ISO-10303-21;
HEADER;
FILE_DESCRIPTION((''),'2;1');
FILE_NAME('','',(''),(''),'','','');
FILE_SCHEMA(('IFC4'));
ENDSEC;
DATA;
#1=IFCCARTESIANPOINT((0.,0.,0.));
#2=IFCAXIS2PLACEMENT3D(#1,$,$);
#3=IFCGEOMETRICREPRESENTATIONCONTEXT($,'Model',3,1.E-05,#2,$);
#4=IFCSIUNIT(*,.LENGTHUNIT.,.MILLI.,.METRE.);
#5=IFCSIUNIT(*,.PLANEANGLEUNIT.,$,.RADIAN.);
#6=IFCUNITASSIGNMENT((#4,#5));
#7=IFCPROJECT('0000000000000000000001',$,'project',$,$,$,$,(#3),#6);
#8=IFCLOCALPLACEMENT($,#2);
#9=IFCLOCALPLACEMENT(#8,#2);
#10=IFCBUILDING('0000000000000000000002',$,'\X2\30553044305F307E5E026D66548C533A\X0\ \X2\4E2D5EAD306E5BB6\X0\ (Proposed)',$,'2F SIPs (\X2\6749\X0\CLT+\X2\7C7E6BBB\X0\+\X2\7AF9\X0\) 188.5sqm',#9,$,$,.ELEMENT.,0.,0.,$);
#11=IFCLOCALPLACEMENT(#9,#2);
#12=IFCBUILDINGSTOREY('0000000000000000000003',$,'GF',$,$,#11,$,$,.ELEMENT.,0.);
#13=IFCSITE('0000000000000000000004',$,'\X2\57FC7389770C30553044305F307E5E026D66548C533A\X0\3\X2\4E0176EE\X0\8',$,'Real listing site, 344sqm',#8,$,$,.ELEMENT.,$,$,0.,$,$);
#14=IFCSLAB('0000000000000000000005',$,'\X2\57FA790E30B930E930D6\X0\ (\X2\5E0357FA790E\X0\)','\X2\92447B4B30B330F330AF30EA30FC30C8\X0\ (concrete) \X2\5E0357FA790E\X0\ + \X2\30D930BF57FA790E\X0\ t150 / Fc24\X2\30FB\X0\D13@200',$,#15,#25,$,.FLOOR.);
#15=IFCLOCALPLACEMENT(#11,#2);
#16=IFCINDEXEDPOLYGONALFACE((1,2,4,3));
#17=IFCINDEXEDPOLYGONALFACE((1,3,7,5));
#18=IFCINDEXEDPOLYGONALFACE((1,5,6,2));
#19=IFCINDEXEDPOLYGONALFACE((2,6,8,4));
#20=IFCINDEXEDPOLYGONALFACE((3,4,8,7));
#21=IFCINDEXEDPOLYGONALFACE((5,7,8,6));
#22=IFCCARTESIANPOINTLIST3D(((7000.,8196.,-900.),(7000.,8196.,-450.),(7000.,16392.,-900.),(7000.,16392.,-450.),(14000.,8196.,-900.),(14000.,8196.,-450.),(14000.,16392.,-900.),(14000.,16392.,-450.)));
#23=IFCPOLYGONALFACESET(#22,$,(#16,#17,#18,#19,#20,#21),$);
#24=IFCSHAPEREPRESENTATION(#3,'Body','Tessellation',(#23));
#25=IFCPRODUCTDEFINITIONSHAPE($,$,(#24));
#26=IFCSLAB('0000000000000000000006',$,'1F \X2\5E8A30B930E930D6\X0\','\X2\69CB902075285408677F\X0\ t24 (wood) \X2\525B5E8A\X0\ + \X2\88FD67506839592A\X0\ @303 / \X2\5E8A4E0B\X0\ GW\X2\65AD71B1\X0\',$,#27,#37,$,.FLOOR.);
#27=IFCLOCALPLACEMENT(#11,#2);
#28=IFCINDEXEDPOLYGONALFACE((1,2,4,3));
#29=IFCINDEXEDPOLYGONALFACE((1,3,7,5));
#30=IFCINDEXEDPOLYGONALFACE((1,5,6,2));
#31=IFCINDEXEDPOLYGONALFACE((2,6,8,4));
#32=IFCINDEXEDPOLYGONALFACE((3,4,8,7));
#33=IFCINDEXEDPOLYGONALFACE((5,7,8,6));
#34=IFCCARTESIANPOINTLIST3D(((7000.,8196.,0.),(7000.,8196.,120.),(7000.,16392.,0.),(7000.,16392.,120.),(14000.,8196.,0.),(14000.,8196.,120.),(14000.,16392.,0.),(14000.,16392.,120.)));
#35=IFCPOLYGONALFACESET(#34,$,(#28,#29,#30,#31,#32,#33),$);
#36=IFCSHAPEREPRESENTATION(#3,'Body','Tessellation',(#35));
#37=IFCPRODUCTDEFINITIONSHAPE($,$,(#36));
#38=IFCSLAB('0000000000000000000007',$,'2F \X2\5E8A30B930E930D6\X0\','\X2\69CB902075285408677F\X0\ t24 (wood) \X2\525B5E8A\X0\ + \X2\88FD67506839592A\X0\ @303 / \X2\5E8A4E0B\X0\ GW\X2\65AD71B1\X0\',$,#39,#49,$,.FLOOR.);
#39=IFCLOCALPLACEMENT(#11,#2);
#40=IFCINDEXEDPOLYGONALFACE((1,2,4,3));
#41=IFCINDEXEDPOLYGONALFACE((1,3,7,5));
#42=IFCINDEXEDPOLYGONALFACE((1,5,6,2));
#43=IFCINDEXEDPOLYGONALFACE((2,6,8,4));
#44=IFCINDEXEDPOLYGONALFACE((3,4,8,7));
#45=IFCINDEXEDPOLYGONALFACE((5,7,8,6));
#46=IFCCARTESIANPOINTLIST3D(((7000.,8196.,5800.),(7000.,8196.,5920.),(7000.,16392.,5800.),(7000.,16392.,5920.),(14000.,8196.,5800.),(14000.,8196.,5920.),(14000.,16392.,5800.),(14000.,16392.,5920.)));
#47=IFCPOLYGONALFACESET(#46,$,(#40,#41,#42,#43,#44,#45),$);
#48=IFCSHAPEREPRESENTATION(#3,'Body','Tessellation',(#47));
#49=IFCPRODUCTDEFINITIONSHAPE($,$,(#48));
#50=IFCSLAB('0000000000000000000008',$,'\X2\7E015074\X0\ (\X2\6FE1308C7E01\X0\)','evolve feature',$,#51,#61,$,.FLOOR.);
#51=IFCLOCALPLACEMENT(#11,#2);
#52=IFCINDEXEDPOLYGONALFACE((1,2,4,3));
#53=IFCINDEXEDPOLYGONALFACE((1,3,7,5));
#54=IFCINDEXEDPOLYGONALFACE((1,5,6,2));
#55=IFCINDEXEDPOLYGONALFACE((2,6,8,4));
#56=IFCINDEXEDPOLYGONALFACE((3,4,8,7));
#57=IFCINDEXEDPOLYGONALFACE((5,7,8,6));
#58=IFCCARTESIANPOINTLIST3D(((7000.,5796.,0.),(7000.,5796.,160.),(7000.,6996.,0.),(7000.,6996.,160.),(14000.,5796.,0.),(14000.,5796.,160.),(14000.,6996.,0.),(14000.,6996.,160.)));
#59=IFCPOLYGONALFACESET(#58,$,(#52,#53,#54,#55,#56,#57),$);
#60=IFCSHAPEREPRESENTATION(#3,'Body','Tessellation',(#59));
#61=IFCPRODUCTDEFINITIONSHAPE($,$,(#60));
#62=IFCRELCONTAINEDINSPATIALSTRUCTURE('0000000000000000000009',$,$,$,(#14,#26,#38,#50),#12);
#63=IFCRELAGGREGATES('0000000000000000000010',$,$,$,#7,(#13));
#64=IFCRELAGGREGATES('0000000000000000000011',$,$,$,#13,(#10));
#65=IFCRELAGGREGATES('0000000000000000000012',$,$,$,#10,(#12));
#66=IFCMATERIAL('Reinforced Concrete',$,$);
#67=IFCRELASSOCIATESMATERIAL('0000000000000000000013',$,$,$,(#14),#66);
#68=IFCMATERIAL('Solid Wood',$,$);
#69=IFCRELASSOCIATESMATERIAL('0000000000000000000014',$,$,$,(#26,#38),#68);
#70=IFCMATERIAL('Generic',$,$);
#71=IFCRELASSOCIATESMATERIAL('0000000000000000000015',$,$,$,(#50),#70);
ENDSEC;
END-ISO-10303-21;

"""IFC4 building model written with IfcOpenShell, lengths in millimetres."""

from ifc_helpers import new_model, si_unit, frame, frame_2d, origin, place, context, project, spatial, rectangle, extrude, material, element, save


model = new_model("IFC4")

# Units and contexts
model_context = context("Model", 3, precision=1e-05, world=origin())
ifc_project = project(units=[si_unit("LENGTHUNIT", "METRE", prefix="MILLI"), si_unit("PLANEANGLEUNIT", "RADIAN")], contexts=[model_context])

# Site, building, storey
site_placement = place(None, origin())
site = spatial("IfcSite", under=ifc_project, at=site_placement, Name="埼玉県さいたま市浦和区3丁目8", ObjectType="Real listing site, 344sqm", CompositionType="ELEMENT", RefElevation=0.0)
building_placement = place(site_placement, origin())
building = spatial("IfcBuilding", under=site, at=building_placement, Name="さいたま市浦和区 中庭の家 (Proposed)", ObjectType="2F SIPs (杉CLT+籾殻+竹) 188.5sqm", CompositionType="ELEMENT", ElevationOfRefHeight=0.0, ElevationOfTerrain=0.0)
storey_placement = place(building_placement, origin())
storey = spatial("IfcBuildingStorey", under=building, at=storey_placement, Name="GF", CompositionType="ELEMENT", Elevation=0.0)

# Slabs
ifc_material_1 = material(Name="Reinforced Concrete")
slab_1_placement = place(storey_placement, frame((3500.0, 4098.0, -450.0)))
element("IfcSlab", 1, at=slab_1_placement, inside=storey, material=ifc_material_1, Name="基礎スラブ (布基礎)", Description="鉄筋コンクリート (concrete) 布基礎 + ベタ基礎 t150 / Fc24・D13@200", PredefinedType="FLOOR", context=model_context, shape_type="SweptSolid", body=[
    extrude(rectangle(XDim=7000.0, YDim=8196.0, at=frame_2d((3500.0, 4098.0))), frame((3500.0, 4098.0, -450.0)), (0.0, 0.0, 1.0), 450.0),
])
ifc_material_2 = material(Name="Solid Wood")
slab_2_placement = place(storey_placement, frame((3500.0, 4098.0, 0.0)))
element("IfcSlab", 2, at=slab_2_placement, inside=storey, material=ifc_material_2, Name="1F 床スラブ", Description="構造用合板 t24 (wood) 剛床 + 製材根太 @303 / 床下 GW断熱", PredefinedType="FLOOR", context=model_context, shape_type="SweptSolid", body=[
    extrude(rectangle(XDim=7000.0, YDim=8196.0, at=frame_2d((3500.0, 4098.0))), frame((3500.0, 4098.0, 0.0)), (0.0, 0.0, 1.0), 120.0),
])
slab_3_placement = place(storey_placement, frame((3500.0, 4098.0, 2900.0)))
element("IfcSlab", 3, at=slab_3_placement, inside=storey, material=ifc_material_2, Name="2F 床スラブ", Description="構造用合板 t24 (wood) 剛床 + 製材根太 @303 / 床下 GW断熱", PredefinedType="FLOOR", context=model_context, shape_type="SweptSolid", body=[
    extrude(rectangle(XDim=7000.0, YDim=8196.0, at=frame_2d((3500.0, 4098.0))), frame((3500.0, 4098.0, 2900.0)), (0.0, 0.0, 1.0), 120.0),
])
ifc_material_3 = material(Name="Generic")
slab_4_placement = place(storey_placement, frame((3500.0, 2898.0, 0.0)))
element("IfcSlab", 4, at=slab_4_placement, inside=storey, material=ifc_material_3, Name="縁側 (濡れ縁)", Description="evolve feature", PredefinedType="FLOOR", context=model_context, shape_type="SweptSolid", body=[
    extrude(rectangle(XDim=7000.0, YDim=1200.0, at=frame_2d((3500.0, 600.0))), frame((3500.0, 2898.0, 0.0)), (0.0, 0.0, 1.0), 160.0),
])

save(model, "model.ifc")
